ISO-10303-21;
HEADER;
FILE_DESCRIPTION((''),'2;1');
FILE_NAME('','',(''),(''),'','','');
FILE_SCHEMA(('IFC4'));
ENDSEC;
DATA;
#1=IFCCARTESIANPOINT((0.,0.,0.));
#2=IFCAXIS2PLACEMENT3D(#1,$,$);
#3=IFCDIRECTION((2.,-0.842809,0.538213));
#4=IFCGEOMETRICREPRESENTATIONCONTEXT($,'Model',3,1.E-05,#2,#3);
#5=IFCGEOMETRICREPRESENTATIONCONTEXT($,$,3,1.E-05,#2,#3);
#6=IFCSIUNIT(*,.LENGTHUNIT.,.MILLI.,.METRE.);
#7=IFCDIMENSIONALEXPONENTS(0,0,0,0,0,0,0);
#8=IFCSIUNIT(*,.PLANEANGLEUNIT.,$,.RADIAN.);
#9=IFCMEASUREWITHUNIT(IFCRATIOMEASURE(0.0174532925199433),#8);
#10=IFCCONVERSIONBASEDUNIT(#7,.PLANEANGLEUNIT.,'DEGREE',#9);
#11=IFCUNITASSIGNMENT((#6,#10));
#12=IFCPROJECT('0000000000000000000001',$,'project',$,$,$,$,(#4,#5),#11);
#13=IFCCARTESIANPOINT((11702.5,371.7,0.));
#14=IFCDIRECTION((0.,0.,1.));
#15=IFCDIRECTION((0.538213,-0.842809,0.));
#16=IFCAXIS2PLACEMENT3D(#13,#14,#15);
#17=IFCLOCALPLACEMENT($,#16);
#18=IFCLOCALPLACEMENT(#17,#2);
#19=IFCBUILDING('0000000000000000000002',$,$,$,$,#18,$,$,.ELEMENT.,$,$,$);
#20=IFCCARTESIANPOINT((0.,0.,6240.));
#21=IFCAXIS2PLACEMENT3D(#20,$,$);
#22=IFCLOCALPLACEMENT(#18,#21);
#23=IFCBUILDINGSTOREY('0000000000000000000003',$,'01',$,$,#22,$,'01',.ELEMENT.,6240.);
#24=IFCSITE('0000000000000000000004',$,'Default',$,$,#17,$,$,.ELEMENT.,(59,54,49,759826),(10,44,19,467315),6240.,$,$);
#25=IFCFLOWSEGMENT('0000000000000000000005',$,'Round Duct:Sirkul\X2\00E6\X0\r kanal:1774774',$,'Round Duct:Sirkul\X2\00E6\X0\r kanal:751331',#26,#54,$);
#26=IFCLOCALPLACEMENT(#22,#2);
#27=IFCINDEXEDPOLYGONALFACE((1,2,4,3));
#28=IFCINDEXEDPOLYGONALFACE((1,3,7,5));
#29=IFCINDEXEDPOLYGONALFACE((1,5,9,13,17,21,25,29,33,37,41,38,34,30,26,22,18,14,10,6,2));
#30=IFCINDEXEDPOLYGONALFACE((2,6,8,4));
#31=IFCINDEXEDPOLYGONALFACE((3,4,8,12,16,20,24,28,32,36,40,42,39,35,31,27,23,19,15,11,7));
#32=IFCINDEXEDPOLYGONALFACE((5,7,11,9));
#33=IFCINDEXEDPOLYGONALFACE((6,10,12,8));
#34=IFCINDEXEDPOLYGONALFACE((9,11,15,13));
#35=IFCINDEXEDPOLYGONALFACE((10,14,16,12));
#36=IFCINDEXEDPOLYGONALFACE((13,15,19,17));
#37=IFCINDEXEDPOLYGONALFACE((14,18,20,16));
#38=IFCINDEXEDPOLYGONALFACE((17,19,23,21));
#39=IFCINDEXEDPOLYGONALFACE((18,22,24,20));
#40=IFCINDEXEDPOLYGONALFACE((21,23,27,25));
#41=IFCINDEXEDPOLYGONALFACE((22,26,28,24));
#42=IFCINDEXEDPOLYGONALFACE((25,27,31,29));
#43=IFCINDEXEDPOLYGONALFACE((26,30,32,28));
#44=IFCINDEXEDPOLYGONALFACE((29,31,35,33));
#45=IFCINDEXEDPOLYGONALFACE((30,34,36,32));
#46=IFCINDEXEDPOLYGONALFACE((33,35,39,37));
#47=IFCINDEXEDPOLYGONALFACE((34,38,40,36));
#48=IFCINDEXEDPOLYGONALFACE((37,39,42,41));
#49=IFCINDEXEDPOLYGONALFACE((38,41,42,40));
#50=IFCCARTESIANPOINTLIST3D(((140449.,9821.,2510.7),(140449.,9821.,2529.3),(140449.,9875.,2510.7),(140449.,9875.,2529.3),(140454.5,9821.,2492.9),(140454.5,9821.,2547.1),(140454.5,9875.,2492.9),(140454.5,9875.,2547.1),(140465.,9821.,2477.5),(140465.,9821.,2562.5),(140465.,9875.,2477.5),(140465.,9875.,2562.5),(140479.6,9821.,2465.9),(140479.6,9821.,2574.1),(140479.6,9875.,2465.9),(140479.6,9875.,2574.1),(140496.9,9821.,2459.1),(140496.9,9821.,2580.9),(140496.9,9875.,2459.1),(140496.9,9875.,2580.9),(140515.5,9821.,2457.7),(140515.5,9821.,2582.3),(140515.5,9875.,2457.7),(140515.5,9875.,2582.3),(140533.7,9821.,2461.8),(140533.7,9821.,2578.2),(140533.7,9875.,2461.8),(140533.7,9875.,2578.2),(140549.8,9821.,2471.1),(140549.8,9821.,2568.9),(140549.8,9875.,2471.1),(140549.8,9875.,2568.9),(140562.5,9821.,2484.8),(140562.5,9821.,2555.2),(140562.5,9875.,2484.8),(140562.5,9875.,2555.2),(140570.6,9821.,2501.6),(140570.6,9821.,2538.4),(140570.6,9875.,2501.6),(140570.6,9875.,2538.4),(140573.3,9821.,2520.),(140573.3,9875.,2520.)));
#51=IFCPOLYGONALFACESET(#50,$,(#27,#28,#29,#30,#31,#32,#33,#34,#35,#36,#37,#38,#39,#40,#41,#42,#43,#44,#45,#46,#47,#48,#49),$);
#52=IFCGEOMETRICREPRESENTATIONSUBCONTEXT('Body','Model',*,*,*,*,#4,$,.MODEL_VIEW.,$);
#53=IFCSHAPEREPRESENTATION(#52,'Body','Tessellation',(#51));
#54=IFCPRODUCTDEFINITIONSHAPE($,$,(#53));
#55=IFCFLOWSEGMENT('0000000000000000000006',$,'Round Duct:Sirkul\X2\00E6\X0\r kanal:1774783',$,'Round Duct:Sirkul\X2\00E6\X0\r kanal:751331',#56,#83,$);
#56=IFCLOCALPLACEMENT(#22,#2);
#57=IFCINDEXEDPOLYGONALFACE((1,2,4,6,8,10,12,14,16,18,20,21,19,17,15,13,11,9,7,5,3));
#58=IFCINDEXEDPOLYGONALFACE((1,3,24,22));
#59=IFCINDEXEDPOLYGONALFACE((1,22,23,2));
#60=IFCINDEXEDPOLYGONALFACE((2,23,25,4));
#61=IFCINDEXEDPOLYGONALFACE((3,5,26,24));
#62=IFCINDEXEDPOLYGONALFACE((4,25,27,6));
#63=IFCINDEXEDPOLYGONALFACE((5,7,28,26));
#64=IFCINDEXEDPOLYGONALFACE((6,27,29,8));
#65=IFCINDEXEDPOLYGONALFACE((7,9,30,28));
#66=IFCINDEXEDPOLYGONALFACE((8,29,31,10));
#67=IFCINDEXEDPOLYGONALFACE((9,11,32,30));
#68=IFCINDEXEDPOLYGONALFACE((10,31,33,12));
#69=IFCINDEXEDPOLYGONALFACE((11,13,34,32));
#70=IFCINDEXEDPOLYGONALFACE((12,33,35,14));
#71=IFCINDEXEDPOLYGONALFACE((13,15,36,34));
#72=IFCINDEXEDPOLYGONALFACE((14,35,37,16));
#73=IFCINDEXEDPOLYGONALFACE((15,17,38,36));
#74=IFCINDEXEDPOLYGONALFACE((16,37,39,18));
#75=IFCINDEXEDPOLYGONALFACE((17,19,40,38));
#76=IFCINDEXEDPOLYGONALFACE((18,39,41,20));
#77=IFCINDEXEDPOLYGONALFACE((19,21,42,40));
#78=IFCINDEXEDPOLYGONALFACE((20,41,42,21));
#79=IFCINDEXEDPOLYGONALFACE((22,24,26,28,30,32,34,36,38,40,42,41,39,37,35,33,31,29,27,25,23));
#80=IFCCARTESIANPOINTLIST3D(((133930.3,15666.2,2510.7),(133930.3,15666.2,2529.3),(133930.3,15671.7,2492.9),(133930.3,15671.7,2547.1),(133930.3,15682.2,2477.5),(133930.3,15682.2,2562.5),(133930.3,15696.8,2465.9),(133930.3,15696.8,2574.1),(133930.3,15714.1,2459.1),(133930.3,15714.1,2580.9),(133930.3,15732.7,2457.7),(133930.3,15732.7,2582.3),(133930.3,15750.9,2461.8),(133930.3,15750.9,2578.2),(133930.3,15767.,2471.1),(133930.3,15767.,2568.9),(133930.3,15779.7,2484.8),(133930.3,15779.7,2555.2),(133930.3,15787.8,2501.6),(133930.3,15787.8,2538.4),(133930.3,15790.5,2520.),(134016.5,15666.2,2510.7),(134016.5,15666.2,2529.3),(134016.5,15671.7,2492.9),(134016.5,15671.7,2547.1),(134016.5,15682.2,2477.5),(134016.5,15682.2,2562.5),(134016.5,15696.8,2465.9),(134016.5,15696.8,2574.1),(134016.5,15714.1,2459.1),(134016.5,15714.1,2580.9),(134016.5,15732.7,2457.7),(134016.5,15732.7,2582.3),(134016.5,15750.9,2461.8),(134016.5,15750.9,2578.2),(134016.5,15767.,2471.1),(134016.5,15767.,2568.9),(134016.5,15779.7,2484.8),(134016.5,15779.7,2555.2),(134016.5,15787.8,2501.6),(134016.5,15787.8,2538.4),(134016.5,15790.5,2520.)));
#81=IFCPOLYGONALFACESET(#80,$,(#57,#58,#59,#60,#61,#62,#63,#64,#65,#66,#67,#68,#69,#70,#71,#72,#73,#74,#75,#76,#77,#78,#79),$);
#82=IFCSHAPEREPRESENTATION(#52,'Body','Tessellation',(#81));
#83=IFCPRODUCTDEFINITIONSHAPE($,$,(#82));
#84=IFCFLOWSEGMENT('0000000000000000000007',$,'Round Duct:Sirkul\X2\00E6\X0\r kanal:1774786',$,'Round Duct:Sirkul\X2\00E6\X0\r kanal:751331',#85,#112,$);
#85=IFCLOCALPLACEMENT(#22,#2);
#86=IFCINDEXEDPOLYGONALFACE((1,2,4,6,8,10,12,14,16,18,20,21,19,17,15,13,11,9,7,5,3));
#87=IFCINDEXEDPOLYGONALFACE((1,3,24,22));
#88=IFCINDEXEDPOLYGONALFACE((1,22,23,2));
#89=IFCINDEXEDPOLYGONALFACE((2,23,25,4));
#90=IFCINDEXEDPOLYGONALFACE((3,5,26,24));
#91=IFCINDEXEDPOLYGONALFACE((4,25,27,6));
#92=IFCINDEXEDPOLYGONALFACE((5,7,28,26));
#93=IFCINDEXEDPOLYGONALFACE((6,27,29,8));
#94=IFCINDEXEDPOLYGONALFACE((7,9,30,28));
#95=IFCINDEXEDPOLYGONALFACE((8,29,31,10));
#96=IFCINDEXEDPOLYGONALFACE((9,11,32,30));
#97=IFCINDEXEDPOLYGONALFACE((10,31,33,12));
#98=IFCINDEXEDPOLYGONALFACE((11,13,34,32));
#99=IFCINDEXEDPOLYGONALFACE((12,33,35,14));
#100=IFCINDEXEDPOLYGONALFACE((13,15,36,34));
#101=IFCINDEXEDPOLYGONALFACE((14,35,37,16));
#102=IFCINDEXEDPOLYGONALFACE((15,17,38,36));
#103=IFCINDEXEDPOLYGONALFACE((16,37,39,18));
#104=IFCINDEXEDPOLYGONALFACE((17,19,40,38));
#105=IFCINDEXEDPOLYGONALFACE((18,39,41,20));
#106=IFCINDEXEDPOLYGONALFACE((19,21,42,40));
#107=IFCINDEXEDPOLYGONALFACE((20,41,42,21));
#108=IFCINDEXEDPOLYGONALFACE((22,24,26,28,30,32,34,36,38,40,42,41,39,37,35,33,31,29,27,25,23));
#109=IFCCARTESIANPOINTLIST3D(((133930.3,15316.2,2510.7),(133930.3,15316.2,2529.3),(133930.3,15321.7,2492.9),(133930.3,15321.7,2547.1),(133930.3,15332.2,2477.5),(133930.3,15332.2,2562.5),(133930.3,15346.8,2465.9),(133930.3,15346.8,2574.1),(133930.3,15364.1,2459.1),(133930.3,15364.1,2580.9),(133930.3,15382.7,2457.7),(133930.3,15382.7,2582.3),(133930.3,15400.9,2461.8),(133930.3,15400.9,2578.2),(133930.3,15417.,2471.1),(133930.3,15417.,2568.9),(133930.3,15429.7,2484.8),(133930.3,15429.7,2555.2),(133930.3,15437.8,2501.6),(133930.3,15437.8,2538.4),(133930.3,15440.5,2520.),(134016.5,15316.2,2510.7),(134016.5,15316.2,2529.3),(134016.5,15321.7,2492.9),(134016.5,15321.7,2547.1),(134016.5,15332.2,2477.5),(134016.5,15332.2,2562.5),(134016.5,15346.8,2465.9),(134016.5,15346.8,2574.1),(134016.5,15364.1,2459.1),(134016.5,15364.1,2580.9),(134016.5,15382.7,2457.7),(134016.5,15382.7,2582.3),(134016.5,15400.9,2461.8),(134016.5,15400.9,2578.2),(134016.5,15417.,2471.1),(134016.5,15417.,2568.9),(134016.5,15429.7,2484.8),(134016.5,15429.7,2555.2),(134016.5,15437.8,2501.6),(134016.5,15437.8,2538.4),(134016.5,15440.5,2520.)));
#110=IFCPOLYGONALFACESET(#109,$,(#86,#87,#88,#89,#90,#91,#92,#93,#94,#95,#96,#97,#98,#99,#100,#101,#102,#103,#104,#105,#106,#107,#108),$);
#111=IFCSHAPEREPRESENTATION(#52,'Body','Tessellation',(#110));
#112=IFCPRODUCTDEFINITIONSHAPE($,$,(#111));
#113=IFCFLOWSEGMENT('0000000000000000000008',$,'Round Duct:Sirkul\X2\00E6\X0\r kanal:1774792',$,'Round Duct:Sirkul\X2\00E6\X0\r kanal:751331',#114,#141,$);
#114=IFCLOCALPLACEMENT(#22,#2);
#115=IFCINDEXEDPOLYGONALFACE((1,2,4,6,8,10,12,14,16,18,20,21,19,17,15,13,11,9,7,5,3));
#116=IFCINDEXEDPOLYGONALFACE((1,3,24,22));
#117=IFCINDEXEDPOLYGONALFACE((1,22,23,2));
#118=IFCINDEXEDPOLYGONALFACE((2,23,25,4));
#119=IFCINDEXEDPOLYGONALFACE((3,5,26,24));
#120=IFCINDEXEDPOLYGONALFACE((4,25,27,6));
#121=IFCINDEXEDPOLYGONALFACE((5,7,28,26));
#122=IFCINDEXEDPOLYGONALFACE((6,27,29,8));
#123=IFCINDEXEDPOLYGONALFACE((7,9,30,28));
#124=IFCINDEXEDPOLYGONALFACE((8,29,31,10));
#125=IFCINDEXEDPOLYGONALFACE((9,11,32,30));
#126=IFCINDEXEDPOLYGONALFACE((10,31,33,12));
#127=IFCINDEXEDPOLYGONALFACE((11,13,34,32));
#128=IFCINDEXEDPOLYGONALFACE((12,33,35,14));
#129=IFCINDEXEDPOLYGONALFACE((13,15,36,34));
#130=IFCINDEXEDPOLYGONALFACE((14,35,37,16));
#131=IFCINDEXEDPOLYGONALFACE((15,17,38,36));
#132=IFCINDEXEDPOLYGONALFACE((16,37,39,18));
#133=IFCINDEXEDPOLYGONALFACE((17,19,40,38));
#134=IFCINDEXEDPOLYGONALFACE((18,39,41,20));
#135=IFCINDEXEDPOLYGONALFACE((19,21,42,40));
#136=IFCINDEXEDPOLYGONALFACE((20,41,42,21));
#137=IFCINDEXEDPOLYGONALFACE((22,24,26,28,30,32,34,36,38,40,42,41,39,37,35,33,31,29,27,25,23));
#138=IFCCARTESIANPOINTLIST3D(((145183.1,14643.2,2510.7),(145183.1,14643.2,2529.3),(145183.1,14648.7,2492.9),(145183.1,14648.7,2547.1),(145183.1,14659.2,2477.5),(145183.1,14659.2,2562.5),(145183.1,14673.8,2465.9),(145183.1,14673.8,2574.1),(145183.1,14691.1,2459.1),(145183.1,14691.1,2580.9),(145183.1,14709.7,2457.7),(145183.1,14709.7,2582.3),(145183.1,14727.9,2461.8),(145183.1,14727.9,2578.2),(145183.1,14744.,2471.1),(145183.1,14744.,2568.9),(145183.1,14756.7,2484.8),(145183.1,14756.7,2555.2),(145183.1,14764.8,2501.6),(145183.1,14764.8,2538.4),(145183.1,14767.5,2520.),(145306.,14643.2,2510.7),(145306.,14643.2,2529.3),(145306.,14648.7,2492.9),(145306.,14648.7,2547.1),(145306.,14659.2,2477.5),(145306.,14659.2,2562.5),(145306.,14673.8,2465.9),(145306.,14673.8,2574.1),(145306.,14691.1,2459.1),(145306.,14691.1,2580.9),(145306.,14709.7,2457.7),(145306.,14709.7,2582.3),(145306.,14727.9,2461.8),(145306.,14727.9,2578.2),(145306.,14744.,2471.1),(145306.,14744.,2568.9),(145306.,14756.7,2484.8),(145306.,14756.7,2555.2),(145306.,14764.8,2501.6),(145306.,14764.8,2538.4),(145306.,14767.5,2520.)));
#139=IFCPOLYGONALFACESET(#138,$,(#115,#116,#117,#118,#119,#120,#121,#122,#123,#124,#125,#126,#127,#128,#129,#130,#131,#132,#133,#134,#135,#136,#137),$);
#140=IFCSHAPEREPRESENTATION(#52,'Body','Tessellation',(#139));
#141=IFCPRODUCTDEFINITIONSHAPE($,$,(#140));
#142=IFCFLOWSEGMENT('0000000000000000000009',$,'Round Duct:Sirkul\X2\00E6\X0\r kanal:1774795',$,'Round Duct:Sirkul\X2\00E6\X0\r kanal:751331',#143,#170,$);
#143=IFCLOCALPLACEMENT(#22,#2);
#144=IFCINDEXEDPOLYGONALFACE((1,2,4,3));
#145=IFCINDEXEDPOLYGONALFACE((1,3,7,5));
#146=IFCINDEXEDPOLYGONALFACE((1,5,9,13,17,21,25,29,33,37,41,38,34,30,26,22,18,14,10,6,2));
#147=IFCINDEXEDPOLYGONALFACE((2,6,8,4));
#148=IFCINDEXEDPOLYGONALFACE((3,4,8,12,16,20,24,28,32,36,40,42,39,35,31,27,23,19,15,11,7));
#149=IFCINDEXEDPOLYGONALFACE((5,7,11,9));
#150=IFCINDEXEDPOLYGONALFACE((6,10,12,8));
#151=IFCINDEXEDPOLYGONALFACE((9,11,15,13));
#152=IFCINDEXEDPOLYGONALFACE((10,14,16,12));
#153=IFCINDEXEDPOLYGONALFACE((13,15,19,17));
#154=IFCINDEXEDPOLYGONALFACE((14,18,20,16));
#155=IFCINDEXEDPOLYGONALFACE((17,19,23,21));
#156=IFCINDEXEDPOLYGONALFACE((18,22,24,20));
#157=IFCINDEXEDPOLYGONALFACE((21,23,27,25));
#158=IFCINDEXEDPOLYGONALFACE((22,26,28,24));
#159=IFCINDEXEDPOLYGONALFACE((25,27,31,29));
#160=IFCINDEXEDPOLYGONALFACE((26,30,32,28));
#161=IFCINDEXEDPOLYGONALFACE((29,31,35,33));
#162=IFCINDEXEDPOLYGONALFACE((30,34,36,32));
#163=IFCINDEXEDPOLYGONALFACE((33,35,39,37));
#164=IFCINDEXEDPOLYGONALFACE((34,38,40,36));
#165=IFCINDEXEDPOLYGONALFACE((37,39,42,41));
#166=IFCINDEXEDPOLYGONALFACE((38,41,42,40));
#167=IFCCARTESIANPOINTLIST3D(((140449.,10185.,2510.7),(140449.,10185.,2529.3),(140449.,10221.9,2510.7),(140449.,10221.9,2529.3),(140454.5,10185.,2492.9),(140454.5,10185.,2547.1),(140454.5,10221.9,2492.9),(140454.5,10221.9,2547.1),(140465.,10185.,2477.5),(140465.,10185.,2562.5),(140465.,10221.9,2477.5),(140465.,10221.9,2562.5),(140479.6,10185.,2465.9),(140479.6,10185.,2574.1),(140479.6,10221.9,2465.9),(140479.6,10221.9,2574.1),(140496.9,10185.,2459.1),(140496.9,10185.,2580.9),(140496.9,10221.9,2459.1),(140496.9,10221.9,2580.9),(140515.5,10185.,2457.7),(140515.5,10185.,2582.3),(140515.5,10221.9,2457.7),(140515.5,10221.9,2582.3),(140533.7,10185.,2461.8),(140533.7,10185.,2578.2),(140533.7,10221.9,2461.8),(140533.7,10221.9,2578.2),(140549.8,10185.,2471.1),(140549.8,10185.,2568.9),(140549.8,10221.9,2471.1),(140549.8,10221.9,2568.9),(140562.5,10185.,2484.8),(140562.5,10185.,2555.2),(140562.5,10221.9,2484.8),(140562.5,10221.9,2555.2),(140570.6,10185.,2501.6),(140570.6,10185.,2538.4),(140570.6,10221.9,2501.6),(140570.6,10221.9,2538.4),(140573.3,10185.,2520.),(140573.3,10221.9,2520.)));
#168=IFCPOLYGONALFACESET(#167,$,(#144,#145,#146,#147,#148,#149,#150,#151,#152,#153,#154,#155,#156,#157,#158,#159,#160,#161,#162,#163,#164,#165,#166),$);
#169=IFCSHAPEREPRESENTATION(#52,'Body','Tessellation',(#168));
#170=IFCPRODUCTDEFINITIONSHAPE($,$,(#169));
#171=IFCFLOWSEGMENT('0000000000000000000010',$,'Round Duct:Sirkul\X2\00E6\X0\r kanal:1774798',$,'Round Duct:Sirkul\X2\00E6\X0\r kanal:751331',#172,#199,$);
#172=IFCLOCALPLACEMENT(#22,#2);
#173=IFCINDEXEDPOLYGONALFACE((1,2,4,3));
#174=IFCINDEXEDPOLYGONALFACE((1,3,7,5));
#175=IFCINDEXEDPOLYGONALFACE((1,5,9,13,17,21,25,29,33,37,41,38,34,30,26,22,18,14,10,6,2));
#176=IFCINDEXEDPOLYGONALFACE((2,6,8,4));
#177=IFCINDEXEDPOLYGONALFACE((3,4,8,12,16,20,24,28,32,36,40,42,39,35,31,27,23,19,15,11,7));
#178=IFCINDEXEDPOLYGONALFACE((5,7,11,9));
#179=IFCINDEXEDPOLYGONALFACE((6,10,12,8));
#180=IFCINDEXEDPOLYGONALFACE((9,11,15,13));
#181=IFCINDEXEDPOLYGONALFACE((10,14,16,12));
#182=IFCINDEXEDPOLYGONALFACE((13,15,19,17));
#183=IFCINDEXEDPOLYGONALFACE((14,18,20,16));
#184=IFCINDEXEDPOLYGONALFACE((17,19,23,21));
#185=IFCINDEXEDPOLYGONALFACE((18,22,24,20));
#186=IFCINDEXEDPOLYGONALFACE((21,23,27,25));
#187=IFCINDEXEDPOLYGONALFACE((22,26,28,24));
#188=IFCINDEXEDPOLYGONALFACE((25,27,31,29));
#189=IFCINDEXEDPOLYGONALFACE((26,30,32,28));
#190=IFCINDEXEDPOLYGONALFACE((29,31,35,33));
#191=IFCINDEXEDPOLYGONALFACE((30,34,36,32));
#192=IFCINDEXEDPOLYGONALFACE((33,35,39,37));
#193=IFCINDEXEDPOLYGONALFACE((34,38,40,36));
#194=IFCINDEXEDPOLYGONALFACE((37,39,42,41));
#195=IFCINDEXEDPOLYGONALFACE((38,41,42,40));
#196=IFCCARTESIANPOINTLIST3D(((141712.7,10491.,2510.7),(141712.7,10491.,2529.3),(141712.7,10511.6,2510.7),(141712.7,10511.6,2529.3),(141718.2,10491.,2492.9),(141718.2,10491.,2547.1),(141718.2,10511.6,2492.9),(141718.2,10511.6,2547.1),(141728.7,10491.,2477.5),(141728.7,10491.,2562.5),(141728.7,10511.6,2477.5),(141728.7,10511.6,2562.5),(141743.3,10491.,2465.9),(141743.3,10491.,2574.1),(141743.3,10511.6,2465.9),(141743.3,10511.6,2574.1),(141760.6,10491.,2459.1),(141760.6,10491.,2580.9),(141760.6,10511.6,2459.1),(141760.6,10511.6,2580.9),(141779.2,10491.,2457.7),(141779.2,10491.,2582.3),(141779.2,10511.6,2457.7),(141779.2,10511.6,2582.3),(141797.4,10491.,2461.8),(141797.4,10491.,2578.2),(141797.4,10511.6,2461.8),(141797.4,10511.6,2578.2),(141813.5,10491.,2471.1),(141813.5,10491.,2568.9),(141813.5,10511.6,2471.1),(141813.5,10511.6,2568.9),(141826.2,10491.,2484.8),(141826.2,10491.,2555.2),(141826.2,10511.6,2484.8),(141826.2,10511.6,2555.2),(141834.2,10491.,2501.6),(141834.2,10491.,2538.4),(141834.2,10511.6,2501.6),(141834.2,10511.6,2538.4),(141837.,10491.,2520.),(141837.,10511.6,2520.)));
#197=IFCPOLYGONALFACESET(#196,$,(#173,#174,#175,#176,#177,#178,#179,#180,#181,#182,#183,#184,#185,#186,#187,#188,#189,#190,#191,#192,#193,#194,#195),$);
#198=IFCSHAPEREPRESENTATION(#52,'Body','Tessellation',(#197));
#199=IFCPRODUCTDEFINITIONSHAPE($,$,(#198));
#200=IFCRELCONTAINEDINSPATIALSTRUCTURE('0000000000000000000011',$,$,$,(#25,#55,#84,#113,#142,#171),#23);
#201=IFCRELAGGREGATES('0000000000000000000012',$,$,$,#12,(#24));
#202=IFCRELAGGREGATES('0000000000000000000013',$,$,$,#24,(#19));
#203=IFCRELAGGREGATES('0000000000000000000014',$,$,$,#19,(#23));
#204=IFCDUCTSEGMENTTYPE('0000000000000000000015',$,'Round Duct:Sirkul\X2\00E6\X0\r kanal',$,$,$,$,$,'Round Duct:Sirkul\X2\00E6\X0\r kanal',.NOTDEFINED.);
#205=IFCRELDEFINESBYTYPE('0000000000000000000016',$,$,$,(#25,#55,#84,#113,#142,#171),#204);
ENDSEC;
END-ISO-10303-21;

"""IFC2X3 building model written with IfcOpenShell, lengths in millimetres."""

from ifc_helpers import new_model, entity, si_unit, converted_unit, direction, frame, frame_2d, origin, origin_2d_with_axis, place, context, subcontext, project, spatial, circle, extrude, type_object, element, save


model = new_model("IFC2X3")

# Units and contexts
model_context = context("Model", 3, precision=1e-05, world=origin(), true_north=direction((2.0, -0.842809, 0.538213)))
context_of_model = context(None, 3, precision=1e-05, world=origin(), true_north=direction((2.0, -0.842809, 0.538213)))
body_context = subcontext(model_context, "Body", "Model", "MODEL_VIEW")
ifc_project = project(units=[si_unit("LENGTHUNIT", "METRE", prefix="MILLI"), converted_unit("PLANEANGLEUNIT", "DEGREE", entity("IfcRatioMeasure", 0.0174532925199433), si_unit("PLANEANGLEUNIT", "RADIAN"), dimensions=[0, 0, 0, 0, 0, 0, 0])], contexts=[model_context, context_of_model])

# Site, building, storey
site_placement = place(None, frame((11702.5, 371.7, 0.0), z_axis=(0.0, 0.0, 1.0), x_axis=(0.538213, -0.842809, 0.0)))
site = spatial("IfcSite", under=ifc_project, at=site_placement, Name="Default", CompositionType="ELEMENT", RefLatitude=(59, 54, 49, 759826), RefLongitude=(10, 44, 19, 467315), RefElevation=6240.0)
building_placement = place(site_placement, origin())
building = spatial("IfcBuilding", under=site, at=building_placement, CompositionType="ELEMENT")
storey_placement = place(building_placement, frame((0.0, 0.0, 6240.0)))
storey = spatial("IfcBuildingStorey", under=building, at=storey_placement, Name="01", LongName="01", CompositionType="ELEMENT", Elevation=6240.0)

# Flow segments
duct_segment_type = type_object("IfcDuctSegmentType", Name="Round Duct:Sirkulær kanal", ElementType="Round Duct:Sirkulær kanal", PredefinedType="NOTDEFINED")
flow_segment_1_placement = place(storey_placement, origin())
element("IfcFlowSegment", 1, at=flow_segment_1_placement, inside=storey, type_object=duct_segment_type, Name="Round Duct:Sirkulær kanal:1774774", ObjectType="Round Duct:Sirkulær kanal:751331", context=body_context, shape_type="SweptSolid", body=[
    extrude(circle(Radius=62.5, at=frame_2d((0.0, 0.0), x_axis=(1.0, 0.0))), frame((140510.8, 9821.0, 2520.0), z_axis=(0.0, 1.0, 0.0), x_axis=(1.0, 0.0, 0.0)), (0.0, 0.0, 1.0), 54.0),
])
flow_segment_2_placement = place(storey_placement, origin())
element("IfcFlowSegment", 2, at=flow_segment_2_placement, inside=storey, type_object=duct_segment_type, Name="Round Duct:Sirkulær kanal:1774783", ObjectType="Round Duct:Sirkulær kanal:751331", context=body_context, shape_type="SweptSolid", body=[
    extrude(circle(Radius=62.5, at=origin_2d_with_axis()), frame((133930.3, 15728.0, 2520.0), z_axis=(1.0, 0.0, 0.0), x_axis=(0.0, 1.0, 0.0)), (0.0, 0.0, 1.0), 86.2),
])
flow_segment_3_placement = place(storey_placement, origin())
element("IfcFlowSegment", 3, at=flow_segment_3_placement, inside=storey, type_object=duct_segment_type, Name="Round Duct:Sirkulær kanal:1774786", ObjectType="Round Duct:Sirkulær kanal:751331", context=body_context, shape_type="SweptSolid", body=[
    extrude(circle(Radius=62.5, at=origin_2d_with_axis()), frame((133930.3, 15378.0, 2520.0), z_axis=(1.0, 0.0, 0.0), x_axis=(0.0, 1.0, 0.0)), (0.0, 0.0, 1.0), 86.2),
])
flow_segment_4_placement = place(storey_placement, origin())
element("IfcFlowSegment", 4, at=flow_segment_4_placement, inside=storey, type_object=duct_segment_type, Name="Round Duct:Sirkulær kanal:1774792", ObjectType="Round Duct:Sirkulær kanal:751331", context=body_context, shape_type="SweptSolid", body=[
    extrude(circle(Radius=62.5, at=origin_2d_with_axis()), frame((145183.1, 14705.0, 2520.0), z_axis=(1.0, 0.0, 0.0), x_axis=(0.0, 1.0, 0.0)), (0.0, 0.0, 1.0), 122.9),
])
flow_segment_5_placement = place(storey_placement, origin())
element("IfcFlowSegment", 5, at=flow_segment_5_placement, inside=storey, type_object=duct_segment_type, Name="Round Duct:Sirkulær kanal:1774795", ObjectType="Round Duct:Sirkulær kanal:751331", context=body_context, shape_type="SweptSolid", body=[
    extrude(circle(Radius=62.5, at=frame_2d((0.0, 0.0), x_axis=(1.0, 0.0))), frame((140510.8, 10185.0, 2520.0), z_axis=(0.0, 1.0, 0.0), x_axis=(1.0, 0.0, 0.0)), (0.0, 0.0, 1.0), 36.9),
])
flow_segment_6_placement = place(storey_placement, origin())
element("IfcFlowSegment", 6, at=flow_segment_6_placement, inside=storey, type_object=duct_segment_type, Name="Round Duct:Sirkulær kanal:1774798", ObjectType="Round Duct:Sirkulær kanal:751331", context=body_context, shape_type="SweptSolid", body=[
    extrude(circle(Radius=62.5, at=frame_2d((0.0, 0.0), x_axis=(1.0, 0.0))), frame((141774.5, 10491.0, 2520.0), z_axis=(0.0, 1.0, 0.0), x_axis=(1.0, 0.0, 0.0)), (0.0, 0.0, 1.0), 20.6),
])

save(model, "model.ifc")
